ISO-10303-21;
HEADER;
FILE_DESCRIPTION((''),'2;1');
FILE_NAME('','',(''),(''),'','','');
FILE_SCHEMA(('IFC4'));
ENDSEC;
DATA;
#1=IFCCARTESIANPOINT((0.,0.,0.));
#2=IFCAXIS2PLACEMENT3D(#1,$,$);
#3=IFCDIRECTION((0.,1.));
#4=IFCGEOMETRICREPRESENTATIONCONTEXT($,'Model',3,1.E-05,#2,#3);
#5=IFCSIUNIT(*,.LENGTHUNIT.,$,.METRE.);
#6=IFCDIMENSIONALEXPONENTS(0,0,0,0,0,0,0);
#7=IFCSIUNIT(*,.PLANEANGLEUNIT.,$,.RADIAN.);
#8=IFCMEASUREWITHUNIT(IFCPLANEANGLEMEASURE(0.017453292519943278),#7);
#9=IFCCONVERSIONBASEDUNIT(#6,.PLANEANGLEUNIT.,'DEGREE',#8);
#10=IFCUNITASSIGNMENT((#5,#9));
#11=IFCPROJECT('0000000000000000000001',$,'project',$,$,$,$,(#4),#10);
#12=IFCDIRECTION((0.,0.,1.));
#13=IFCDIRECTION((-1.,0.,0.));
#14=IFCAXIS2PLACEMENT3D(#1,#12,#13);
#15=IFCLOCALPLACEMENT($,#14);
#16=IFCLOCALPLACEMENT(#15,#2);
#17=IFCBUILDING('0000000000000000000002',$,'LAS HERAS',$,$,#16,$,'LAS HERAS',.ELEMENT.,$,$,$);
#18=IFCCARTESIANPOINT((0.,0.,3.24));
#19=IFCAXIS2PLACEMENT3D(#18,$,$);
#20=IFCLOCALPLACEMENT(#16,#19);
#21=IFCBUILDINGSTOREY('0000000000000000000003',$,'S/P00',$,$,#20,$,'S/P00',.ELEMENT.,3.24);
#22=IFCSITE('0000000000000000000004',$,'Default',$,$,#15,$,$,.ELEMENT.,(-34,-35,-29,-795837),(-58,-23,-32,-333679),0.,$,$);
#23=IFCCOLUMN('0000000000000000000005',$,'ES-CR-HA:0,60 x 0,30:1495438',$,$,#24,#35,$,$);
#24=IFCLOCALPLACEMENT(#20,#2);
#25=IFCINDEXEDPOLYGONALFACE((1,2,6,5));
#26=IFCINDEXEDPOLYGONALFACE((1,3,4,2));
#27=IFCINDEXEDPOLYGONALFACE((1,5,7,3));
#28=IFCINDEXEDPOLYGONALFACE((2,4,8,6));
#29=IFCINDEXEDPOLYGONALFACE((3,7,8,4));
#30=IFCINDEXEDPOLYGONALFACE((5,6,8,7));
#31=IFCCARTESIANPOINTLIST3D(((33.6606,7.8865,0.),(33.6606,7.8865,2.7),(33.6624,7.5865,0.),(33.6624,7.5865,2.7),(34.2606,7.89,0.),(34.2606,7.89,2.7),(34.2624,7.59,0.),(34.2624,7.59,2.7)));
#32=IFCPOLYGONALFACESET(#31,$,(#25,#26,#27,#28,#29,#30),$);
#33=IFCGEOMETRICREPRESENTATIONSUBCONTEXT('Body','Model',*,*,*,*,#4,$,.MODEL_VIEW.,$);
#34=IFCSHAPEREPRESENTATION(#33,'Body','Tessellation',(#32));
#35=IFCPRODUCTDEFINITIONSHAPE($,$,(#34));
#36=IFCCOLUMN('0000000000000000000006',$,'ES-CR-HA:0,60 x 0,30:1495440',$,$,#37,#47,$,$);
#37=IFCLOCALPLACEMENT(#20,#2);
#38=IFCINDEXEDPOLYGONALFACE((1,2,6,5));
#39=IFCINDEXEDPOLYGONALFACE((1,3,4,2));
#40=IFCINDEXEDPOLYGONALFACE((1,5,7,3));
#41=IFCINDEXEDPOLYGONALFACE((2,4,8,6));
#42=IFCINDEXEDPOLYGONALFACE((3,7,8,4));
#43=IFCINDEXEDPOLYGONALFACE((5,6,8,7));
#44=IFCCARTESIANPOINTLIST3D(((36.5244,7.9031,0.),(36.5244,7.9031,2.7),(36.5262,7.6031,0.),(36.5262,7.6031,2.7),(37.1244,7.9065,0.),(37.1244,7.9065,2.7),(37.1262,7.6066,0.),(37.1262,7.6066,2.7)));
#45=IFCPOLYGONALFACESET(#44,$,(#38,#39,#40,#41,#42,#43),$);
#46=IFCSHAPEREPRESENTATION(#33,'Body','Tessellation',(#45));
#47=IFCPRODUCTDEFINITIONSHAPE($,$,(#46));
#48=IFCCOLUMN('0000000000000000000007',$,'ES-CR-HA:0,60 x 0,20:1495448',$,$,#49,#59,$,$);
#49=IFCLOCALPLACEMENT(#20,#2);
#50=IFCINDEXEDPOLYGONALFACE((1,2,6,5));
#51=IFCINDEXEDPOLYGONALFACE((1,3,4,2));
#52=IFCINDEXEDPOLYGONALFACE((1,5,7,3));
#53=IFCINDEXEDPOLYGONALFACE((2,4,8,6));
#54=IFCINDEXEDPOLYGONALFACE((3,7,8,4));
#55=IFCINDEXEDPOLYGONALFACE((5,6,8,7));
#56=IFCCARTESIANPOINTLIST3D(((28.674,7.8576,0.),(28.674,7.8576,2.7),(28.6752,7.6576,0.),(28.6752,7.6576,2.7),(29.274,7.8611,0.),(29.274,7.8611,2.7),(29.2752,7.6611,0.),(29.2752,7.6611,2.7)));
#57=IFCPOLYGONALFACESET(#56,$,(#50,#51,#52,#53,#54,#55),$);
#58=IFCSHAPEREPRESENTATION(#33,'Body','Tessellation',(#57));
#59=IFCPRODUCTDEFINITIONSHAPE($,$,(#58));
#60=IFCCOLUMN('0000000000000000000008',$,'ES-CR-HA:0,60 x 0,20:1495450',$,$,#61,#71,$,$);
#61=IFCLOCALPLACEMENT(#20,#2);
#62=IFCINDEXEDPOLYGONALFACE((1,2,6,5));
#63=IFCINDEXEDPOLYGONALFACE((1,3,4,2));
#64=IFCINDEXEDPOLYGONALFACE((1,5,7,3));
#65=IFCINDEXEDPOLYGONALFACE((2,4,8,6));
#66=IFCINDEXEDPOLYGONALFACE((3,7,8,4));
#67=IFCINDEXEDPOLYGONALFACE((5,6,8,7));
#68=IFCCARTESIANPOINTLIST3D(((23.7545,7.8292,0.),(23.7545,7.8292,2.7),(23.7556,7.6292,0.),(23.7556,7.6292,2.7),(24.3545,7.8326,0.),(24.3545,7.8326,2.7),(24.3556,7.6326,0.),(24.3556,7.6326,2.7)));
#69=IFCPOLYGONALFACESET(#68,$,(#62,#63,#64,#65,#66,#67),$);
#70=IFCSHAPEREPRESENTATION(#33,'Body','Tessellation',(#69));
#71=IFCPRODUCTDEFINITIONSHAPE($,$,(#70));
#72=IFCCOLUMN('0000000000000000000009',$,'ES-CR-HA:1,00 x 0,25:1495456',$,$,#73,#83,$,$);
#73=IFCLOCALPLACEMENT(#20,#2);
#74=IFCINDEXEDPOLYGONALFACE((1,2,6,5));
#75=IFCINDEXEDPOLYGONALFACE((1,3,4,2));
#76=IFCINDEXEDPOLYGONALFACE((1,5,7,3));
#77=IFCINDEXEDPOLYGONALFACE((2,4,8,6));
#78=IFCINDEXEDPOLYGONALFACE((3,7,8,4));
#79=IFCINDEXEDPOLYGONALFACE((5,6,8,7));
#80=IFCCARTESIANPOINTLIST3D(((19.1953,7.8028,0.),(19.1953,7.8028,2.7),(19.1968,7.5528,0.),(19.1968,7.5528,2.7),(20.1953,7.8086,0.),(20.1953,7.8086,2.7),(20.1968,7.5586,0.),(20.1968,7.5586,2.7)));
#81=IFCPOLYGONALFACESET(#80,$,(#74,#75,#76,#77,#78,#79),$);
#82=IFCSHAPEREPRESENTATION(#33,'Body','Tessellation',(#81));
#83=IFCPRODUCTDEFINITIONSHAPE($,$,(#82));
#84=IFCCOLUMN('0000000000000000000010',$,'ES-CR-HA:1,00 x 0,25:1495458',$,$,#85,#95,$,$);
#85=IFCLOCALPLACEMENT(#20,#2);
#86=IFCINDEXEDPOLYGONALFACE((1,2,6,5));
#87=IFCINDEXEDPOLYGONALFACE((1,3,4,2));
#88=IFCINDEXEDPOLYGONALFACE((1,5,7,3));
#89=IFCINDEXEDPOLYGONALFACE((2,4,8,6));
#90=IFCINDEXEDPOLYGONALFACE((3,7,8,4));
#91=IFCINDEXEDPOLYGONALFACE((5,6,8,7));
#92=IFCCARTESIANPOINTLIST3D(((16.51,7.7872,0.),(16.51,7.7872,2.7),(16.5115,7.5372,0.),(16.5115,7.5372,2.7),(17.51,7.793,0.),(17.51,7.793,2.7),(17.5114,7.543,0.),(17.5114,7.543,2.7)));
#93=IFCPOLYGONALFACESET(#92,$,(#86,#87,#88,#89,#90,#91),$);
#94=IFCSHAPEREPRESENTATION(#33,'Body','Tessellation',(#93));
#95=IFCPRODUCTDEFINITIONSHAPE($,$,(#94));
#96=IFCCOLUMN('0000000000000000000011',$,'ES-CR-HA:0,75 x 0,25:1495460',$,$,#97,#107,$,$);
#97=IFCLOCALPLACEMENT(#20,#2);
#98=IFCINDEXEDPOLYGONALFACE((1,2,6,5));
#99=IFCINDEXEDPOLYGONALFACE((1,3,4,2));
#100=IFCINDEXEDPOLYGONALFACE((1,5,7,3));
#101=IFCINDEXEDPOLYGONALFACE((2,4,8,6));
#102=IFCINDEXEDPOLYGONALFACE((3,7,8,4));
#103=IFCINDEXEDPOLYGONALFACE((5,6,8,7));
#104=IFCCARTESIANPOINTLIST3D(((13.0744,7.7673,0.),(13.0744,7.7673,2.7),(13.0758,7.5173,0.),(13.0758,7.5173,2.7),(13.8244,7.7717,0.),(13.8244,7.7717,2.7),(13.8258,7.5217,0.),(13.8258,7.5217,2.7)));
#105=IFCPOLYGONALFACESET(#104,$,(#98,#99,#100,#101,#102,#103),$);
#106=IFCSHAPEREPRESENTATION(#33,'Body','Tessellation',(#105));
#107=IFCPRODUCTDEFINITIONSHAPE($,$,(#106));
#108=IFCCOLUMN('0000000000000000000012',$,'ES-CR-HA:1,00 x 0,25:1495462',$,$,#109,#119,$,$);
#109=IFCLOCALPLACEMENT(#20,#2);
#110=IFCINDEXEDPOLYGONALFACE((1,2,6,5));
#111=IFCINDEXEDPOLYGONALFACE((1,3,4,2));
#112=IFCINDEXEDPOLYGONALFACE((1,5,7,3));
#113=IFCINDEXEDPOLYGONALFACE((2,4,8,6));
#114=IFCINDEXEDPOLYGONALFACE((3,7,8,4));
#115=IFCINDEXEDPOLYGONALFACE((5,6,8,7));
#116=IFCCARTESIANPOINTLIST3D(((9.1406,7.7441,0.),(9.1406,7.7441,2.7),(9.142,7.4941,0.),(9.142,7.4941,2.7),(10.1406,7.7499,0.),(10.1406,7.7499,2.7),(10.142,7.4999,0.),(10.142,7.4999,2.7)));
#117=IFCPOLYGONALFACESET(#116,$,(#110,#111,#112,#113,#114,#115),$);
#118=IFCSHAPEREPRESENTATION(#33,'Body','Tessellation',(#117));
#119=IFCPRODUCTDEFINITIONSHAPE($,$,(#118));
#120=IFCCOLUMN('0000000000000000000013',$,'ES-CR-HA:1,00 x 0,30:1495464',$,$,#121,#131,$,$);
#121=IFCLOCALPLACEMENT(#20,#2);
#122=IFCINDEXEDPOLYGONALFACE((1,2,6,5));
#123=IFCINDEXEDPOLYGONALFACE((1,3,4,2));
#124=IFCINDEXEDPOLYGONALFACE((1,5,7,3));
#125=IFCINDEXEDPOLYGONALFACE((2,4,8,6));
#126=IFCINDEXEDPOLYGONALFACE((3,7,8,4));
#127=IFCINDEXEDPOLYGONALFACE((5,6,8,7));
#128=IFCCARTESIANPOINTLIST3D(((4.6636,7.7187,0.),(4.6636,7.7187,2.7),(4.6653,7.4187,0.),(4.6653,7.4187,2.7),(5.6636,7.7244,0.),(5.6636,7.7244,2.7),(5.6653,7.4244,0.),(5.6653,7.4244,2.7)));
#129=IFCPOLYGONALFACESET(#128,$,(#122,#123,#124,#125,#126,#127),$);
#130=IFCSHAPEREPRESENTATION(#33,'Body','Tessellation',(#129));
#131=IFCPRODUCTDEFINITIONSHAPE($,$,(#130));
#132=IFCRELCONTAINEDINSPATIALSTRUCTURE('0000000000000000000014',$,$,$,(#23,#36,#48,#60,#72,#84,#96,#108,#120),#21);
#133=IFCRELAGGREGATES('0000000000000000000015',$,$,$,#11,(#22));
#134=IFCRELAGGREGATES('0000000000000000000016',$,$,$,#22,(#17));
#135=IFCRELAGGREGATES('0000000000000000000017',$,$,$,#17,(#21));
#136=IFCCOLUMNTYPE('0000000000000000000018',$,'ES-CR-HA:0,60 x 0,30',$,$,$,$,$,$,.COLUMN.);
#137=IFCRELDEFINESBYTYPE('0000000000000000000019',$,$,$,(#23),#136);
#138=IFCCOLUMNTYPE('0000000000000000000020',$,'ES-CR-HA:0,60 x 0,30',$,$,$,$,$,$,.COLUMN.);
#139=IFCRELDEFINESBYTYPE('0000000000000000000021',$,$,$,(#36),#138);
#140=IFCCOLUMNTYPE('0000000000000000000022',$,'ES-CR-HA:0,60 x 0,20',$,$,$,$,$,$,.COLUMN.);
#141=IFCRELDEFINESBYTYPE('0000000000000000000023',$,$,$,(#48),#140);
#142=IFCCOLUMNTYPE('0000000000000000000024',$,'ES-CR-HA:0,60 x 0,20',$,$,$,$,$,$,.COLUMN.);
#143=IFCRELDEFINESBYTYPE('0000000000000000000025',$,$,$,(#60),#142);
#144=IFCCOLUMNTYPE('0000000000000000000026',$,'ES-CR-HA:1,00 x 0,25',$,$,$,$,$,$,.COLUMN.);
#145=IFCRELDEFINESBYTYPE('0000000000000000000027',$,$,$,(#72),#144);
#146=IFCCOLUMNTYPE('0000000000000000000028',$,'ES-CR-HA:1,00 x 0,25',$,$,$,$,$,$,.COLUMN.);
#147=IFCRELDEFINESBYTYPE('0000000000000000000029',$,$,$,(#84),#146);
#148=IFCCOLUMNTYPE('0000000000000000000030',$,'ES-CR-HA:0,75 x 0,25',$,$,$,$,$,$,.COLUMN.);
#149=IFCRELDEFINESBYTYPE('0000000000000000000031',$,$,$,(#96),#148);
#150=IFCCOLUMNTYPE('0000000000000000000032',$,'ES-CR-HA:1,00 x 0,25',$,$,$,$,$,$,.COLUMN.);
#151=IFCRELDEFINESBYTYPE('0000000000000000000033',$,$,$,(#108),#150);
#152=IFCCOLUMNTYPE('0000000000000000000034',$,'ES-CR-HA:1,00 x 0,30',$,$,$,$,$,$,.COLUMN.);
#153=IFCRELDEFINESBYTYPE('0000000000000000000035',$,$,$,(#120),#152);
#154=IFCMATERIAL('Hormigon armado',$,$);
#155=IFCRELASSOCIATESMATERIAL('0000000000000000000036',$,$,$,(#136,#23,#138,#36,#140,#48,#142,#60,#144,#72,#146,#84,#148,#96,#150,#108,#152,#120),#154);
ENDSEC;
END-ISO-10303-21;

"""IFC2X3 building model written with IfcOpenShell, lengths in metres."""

from ifc_helpers import new_model, entity, si_unit, converted_unit, direction, frame, frame_2d, origin, place, context, subcontext, project, spatial, rectangle, extrude, source, transform, mapped, material, type_object, type_shapes, element, save


model = new_model("IFC2X3")

# Units and contexts
model_context = context("Model", 3, precision=1e-05, world=origin(), true_north=direction((0.0, 1.0)))
body_context = subcontext(model_context, "Body", "Model", "MODEL_VIEW")
ifc_project = project(units=[si_unit("LENGTHUNIT", "METRE"), converted_unit("PLANEANGLEUNIT", "DEGREE", entity("IfcPlaneAngleMeasure", 0.017453292519943278), si_unit("PLANEANGLEUNIT", "RADIAN"), dimensions=[0, 0, 0, 0, 0, 0, 0])], contexts=[model_context])

# Site, building, storey
site_placement = place(None, frame((0.0, 0.0, 0.0), z_axis=(0.0, 0.0, 1.0), x_axis=(-1.0, 0.0, 0.0)))
site = spatial("IfcSite", under=ifc_project, at=site_placement, Name="Default", CompositionType="ELEMENT", RefLatitude=(-34, -35, -29, -795837), RefLongitude=(-58, -23, -32, -333679), RefElevation=0.0)
building_placement = place(site_placement, origin())
building = spatial("IfcBuilding", under=site, at=building_placement, Name="LAS HERAS", LongName="LAS HERAS", CompositionType="ELEMENT")
storey_placement = place(building_placement, frame((0.0, 0.0, 3.24)))
storey = spatial("IfcBuildingStorey", under=building, at=storey_placement, Name="S/P00", LongName="S/P00", CompositionType="ELEMENT", Elevation=3.24)

# Columns
ifc_material = material(Name="Hormigon armado")
column_type_1 = type_object("IfcColumnType", Name="ES-CR-HA:0,60 x 0,30", PredefinedType="COLUMN", material=ifc_material)
shared_shape_1 = source(origin(), body_context, "Body", "SweptSolid", [
    extrude(rectangle(XDim=2.7, YDim=0.3, at=frame_2d((0.0, 0.0), x_axis=(1.0, 0.0))), frame((33.6615, 7.7365, 4.59), z_axis=(0.999983, 0.005788, 0.0), x_axis=(0.0, 0.0, 1.0)), (0.0, 0.0, 1.0), 0.6),
])
type_shapes(column_type_1, [shared_shape_1])
column_1_placement = place(storey_placement, frame((0.0, 0.0, -3.24)))
element("IfcColumn", 1, at=column_1_placement, inside=storey, type_object=column_type_1, material=ifc_material, Name="ES-CR-HA:0,60 x 0,30:1495438", context=body_context, shape_type="MappedRepresentation", body=[
    mapped(shared_shape_1, transform((0.0, 0.0, 0.0), scale=1.0)),
])
column_type_2 = type_object("IfcColumnType", Name="ES-CR-HA:0,60 x 0,30", PredefinedType="COLUMN", material=ifc_material)
shared_shape_2 = source(origin(), body_context, "Body", "SweptSolid", [
    extrude(rectangle(XDim=2.7, YDim=0.3, at=frame_2d((0.0, 0.0033), x_axis=(1.0, 0.0))), frame((36.5253, 7.7564, 4.59), z_axis=(0.999983, 0.005788, 0.0), x_axis=(0.0, 0.0, 1.0)), (0.0, 0.0, 1.0), 0.6),
])
type_shapes(column_type_2, [shared_shape_2])
column_2_placement = place(storey_placement, frame((0.0, 0.0, -3.24)))
element("IfcColumn", 2, at=column_2_placement, inside=storey, type_object=column_type_2, material=ifc_material, Name="ES-CR-HA:0,60 x 0,30:1495440", context=body_context, shape_type="MappedRepresentation", body=[
    mapped(shared_shape_2, transform((0.0, 0.0, 0.0), scale=1.0)),
])
column_type_3 = type_object("IfcColumnType", Name="ES-CR-HA:0,60 x 0,20", PredefinedType="COLUMN", material=ifc_material)
shared_shape_3 = source(origin(), body_context, "Body", "SweptSolid", [
    extrude(rectangle(XDim=2.7, YDim=0.2, at=frame_2d((0.0, 0.0), x_axis=(1.0, 0.0))), frame((28.6746, 7.7576, 4.59), z_axis=(0.999983, 0.005788, 0.0), x_axis=(0.0, 0.0, 1.0)), (0.0, 0.0, 1.0), 0.6),
])
type_shapes(column_type_3, [shared_shape_3])
column_3_placement = place(storey_placement, frame((0.0, 0.0, -3.24)))
element("IfcColumn", 3, at=column_3_placement, inside=storey, type_object=column_type_3, material=ifc_material, Name="ES-CR-HA:0,60 x 0,20:1495448", context=body_context, shape_type="MappedRepresentation", body=[
    mapped(shared_shape_3, transform((0.0, 0.0, 0.0), scale=1.0)),
])
column_type_4 = type_object("IfcColumnType", Name="ES-CR-HA:0,60 x 0,20", PredefinedType="COLUMN", material=ifc_material)
shared_shape_4 = source(origin(), body_context, "Body", "SweptSolid", [
    extrude(rectangle(XDim=2.7, YDim=0.2, at=frame_2d((0.0, 0.0), x_axis=(1.0, 0.0))), frame((23.7551, 7.7292, 4.59), z_axis=(0.999983, 0.005788, 0.0), x_axis=(0.0, 0.0, 1.0)), (0.0, 0.0, 1.0), 0.6),
])
type_shapes(column_type_4, [shared_shape_4])
column_4_placement = place(storey_placement, frame((0.0, 0.0, -3.24)))
element("IfcColumn", 4, at=column_4_placement, inside=storey, type_object=column_type_4, material=ifc_material, Name="ES-CR-HA:0,60 x 0,20:1495450", context=body_context, shape_type="MappedRepresentation", body=[
    mapped(shared_shape_4, transform((0.0, 0.0, 0.0), scale=1.0)),
])
column_type_5 = type_object("IfcColumnType", Name="ES-CR-HA:1,00 x 0,25", PredefinedType="COLUMN", material=ifc_material)
shared_shape_5 = source(origin(), body_context, "Body", "SweptSolid", [
    extrude(rectangle(XDim=2.7, YDim=0.25, at=frame_2d((0.0, 0.0), x_axis=(1.0, 0.0))), frame((19.1961, 7.6778, 4.59), z_axis=(0.999983, 0.005788, 0.0), x_axis=(0.0, 0.0, 1.0)), (0.0, 0.0, 1.0), 1.0),
])
type_shapes(column_type_5, [shared_shape_5])
column_5_placement = place(storey_placement, frame((0.0, 0.0, -3.24)))
element("IfcColumn", 5, at=column_5_placement, inside=storey, type_object=column_type_5, material=ifc_material, Name="ES-CR-HA:1,00 x 0,25:1495456", context=body_context, shape_type="MappedRepresentation", body=[
    mapped(shared_shape_5, transform((0.0, 0.0, 0.0), scale=1.0)),
])
column_type_6 = type_object("IfcColumnType", Name="ES-CR-HA:1,00 x 0,25", PredefinedType="COLUMN", material=ifc_material)
shared_shape_6 = source(origin(), body_context, "Body", "SweptSolid", [
    extrude(rectangle(XDim=2.7, YDim=0.25, at=frame_2d((0.0, 0.0), x_axis=(1.0, 0.0))), frame((16.5107, 7.6622, 4.59), z_axis=(0.999983, 0.005788, 0.0), x_axis=(0.0, 0.0, 1.0)), (0.0, 0.0, 1.0), 1.0),
])
type_shapes(column_type_6, [shared_shape_6])
column_6_placement = place(storey_placement, frame((0.0, 0.0, -3.24)))
element("IfcColumn", 6, at=column_6_placement, inside=storey, type_object=column_type_6, material=ifc_material, Name="ES-CR-HA:1,00 x 0,25:1495458", context=body_context, shape_type="MappedRepresentation", body=[
    mapped(shared_shape_6, transform((0.0, 0.0, 0.0), scale=1.0)),
])
column_type_7 = type_object("IfcColumnType", Name="ES-CR-HA:0,75 x 0,25", PredefinedType="COLUMN", material=ifc_material)
shared_shape_7 = source(origin(), body_context, "Body", "SweptSolid", [
    extrude(rectangle(XDim=2.7, YDim=0.25, at=frame_2d((0.0, 0.0), x_axis=(1.0, 0.0))), frame((13.0751, 7.6423, 4.59), z_axis=(0.999983, 0.005788, 0.0), x_axis=(0.0, 0.0, 1.0)), (0.0, 0.0, 1.0), 0.75),
])
type_shapes(column_type_7, [shared_shape_7])
column_7_placement = place(storey_placement, frame((0.0, 0.0, -3.24)))
element("IfcColumn", 7, at=column_7_placement, inside=storey, type_object=column_type_7, material=ifc_material, Name="ES-CR-HA:0,75 x 0,25:1495460", context=body_context, shape_type="MappedRepresentation", body=[
    mapped(shared_shape_7, transform((0.0, 0.0, 0.0), scale=1.0)),
])
column_type_8 = type_object("IfcColumnType", Name="ES-CR-HA:1,00 x 0,25", PredefinedType="COLUMN", material=ifc_material)
shared_shape_8 = source(origin(), body_context, "Body", "SweptSolid", [
    extrude(rectangle(XDim=2.7, YDim=0.25, at=frame_2d((0.0, 0.0), x_axis=(1.0, 0.0))), frame((9.1413, 7.6191, 4.59), z_axis=(0.999983, 0.005788, 0.0), x_axis=(0.0, 0.0, 1.0)), (0.0, 0.0, 1.0), 1.0),
])
type_shapes(column_type_8, [shared_shape_8])
column_8_placement = place(storey_placement, frame((0.0, 0.0, -3.24)))
element("IfcColumn", 8, at=column_8_placement, inside=storey, type_object=column_type_8, material=ifc_material, Name="ES-CR-HA:1,00 x 0,25:1495462", context=body_context, shape_type="MappedRepresentation", body=[
    mapped(shared_shape_8, transform((0.0, 0.0, 0.0), scale=1.0)),
])
column_type_9 = type_object("IfcColumnType", Name="ES-CR-HA:1,00 x 0,30", PredefinedType="COLUMN", material=ifc_material)
shared_shape_9 = source(origin(), body_context, "Body", "SweptSolid", [
    extrude(rectangle(XDim=2.7, YDim=0.3, at=frame_2d((0.0, 0.0), x_axis=(1.0, 0.0))), frame((4.6645, 7.5687, 4.59), z_axis=(0.999983, 0.005788, 0.0), x_axis=(0.0, 0.0, 1.0)), (0.0, 0.0, 1.0), 1.0),
])
type_shapes(column_type_9, [shared_shape_9])
column_9_placement = place(storey_placement, frame((0.0, 0.0, -3.24)))
element("IfcColumn", 9, at=column_9_placement, inside=storey, type_object=column_type_9, material=ifc_material, Name="ES-CR-HA:1,00 x 0,30:1495464", context=body_context, shape_type="MappedRepresentation", body=[
    mapped(shared_shape_9, transform((0.0, 0.0, 0.0), scale=1.0)),
])

save(model, "model.ifc")
